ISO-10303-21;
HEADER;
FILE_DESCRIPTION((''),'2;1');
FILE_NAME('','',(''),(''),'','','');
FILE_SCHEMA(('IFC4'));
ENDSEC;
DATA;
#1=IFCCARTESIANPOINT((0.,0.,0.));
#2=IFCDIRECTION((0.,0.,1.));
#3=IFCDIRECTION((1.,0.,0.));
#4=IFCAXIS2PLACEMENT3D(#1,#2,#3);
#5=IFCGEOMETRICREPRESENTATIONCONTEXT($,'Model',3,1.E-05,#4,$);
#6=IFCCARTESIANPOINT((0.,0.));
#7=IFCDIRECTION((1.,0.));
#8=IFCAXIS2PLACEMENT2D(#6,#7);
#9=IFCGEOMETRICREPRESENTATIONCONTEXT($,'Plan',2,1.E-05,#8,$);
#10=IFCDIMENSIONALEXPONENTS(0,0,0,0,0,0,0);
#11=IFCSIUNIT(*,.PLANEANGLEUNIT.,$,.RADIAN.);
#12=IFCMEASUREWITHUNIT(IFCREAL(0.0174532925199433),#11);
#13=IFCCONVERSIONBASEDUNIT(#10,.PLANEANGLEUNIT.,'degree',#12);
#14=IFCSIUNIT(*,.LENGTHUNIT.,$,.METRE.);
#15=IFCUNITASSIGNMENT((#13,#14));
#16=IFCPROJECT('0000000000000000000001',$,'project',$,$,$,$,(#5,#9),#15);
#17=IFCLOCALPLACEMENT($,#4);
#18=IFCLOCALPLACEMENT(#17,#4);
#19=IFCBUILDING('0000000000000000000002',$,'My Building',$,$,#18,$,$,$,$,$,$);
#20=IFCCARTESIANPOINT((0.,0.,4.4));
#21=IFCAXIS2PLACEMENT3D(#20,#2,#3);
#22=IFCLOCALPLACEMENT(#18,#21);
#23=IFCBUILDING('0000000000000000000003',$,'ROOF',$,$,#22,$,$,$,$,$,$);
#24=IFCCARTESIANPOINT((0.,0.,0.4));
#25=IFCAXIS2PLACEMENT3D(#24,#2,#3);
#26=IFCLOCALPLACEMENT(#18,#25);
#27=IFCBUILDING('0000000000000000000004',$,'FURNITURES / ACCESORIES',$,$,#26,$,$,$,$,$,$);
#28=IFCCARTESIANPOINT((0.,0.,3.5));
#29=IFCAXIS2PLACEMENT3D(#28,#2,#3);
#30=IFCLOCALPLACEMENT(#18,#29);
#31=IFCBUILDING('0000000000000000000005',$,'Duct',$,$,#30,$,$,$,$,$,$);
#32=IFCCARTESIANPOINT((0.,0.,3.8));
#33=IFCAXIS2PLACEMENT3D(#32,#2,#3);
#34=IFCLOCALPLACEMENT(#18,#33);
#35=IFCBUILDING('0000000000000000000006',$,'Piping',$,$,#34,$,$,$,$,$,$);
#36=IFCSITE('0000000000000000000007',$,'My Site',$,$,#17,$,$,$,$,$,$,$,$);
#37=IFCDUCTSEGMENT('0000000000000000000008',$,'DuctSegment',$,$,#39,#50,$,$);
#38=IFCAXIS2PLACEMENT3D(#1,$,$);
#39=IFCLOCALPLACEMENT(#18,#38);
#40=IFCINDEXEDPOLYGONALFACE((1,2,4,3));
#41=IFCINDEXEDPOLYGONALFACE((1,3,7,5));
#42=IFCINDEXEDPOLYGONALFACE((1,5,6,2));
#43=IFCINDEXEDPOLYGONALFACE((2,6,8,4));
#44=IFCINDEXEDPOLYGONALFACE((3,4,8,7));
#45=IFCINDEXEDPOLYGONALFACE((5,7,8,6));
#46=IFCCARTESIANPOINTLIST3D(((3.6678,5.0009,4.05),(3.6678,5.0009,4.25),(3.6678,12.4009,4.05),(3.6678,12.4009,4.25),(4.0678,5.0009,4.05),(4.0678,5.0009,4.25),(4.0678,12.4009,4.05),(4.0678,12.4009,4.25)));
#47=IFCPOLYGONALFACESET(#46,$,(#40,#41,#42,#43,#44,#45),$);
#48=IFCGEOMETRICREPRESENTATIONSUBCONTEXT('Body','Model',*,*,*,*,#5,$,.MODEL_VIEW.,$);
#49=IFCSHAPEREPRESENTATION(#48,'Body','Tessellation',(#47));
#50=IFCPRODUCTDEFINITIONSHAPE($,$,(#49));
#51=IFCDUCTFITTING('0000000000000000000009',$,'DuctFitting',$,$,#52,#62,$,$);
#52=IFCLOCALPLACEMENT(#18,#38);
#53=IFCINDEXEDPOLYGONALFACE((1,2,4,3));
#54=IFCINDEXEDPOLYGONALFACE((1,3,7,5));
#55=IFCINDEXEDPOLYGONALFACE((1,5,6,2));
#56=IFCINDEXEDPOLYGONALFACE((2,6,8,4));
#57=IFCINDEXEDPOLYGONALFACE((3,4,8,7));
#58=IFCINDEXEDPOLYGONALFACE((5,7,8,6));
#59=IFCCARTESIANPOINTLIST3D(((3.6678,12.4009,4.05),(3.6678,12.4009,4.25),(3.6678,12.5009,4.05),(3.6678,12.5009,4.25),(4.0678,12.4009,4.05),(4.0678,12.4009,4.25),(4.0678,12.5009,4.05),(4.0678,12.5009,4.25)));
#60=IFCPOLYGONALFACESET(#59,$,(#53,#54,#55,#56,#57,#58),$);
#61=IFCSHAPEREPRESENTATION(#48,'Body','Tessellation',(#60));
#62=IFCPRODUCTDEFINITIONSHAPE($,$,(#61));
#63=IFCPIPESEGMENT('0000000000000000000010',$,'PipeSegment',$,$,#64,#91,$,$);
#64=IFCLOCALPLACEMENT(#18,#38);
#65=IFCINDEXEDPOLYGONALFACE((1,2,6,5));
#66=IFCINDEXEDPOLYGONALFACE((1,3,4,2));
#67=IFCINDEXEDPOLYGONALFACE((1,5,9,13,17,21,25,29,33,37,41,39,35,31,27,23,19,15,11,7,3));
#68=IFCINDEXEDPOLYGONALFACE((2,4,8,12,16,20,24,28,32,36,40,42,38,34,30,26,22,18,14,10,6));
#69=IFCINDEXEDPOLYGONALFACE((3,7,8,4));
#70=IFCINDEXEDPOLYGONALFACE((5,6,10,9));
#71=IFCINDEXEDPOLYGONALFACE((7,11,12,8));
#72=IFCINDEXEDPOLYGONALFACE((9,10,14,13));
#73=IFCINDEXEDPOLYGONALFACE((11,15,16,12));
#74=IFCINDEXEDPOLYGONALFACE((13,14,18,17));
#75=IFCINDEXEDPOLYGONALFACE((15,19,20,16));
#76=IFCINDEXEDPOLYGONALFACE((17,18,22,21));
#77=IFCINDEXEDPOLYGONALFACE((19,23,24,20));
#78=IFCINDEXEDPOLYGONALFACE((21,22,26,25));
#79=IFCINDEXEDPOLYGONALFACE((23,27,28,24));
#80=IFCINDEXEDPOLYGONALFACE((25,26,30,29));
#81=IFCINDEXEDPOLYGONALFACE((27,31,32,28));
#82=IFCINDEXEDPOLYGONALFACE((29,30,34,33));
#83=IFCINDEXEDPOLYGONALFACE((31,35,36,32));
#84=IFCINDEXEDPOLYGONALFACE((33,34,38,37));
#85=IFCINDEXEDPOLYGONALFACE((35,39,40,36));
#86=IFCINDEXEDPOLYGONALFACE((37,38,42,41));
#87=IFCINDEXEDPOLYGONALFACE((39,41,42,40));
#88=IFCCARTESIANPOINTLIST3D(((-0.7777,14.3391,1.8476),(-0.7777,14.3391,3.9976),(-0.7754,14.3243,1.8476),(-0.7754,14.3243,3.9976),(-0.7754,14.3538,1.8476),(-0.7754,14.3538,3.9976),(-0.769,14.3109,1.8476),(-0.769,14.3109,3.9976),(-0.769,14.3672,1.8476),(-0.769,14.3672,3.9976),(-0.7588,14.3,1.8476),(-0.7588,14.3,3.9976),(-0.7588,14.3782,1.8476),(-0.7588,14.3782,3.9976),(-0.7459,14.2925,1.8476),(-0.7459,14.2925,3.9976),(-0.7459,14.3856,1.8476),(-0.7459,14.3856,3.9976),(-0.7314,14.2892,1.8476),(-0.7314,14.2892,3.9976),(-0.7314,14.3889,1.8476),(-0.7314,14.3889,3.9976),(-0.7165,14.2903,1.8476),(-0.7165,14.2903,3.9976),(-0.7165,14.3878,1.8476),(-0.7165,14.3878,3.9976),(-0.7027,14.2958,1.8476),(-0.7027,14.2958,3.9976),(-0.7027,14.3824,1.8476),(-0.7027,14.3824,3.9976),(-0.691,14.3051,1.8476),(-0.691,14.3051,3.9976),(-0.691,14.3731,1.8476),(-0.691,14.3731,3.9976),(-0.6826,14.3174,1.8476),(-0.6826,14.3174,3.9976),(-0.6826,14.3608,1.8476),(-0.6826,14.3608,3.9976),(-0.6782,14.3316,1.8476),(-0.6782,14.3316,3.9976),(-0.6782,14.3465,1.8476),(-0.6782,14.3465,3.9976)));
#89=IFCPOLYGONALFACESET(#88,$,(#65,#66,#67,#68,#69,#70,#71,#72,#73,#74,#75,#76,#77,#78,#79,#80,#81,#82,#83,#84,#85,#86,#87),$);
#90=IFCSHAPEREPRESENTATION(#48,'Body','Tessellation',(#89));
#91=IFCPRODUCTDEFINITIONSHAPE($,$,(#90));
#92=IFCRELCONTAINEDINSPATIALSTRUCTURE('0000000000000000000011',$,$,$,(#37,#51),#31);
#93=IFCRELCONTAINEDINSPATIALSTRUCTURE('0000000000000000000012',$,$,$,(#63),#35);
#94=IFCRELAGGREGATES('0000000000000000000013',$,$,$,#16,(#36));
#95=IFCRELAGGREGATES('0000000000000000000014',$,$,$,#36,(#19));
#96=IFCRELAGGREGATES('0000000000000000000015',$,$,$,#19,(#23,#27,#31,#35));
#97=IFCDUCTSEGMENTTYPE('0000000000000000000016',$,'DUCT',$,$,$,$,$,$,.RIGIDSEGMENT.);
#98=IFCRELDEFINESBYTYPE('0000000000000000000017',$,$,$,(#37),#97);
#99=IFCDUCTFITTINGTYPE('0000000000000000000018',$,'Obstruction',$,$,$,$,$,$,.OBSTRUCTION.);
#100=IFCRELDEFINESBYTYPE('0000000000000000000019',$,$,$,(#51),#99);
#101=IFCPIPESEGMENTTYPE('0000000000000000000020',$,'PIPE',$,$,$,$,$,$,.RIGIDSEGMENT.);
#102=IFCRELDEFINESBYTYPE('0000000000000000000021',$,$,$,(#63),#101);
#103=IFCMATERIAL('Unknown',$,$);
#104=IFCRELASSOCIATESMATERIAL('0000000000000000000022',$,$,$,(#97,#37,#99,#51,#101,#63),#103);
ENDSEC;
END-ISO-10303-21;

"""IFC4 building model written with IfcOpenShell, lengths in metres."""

from ifc_helpers import new_model, entity, si_unit, converted_unit, frame, origin_with_axes, origin_2d_with_axis, place, context, subcontext, project, spatial, rectangle, circle, extrude, material, material_profile, profile_set, profile_usage, type_object, element, save


model = new_model("IFC4")

# Units and contexts
model_context = context("Model", 3, precision=1e-05, world=origin_with_axes())
plan_context = context("Plan", 2, precision=1e-05, world=origin_2d_with_axis())
body_context_1 = subcontext(model_context, "Body", "Model", "MODEL_VIEW")
ifc_project = project(units=[converted_unit("PLANEANGLEUNIT", "degree", entity("IfcReal", 0.0174532925199433), si_unit("PLANEANGLEUNIT", "RADIAN"), dimensions=[0, 0, 0, 0, 0, 0, 0]), si_unit("LENGTHUNIT", "METRE")], contexts=[model_context, plan_context])

# Site, building
site_placement = place(None, origin_with_axes())
site = spatial("IfcSite", under=ifc_project, at=site_placement, Name="My Site")
building_1_placement = place(site_placement, origin_with_axes())
building_1 = spatial("IfcBuilding", under=site, at=building_1_placement, Name="My Building")

# Shared definitions
ifc_material = material(Name="Unknown")

# Shared definitions
building_2_placement = place(building_1_placement, frame((0.0, 0.0, 4.4), z_axis=(0.0, 0.0, 1.0), x_axis=(1.0, 0.0, 0.0)))
building_2 = spatial("IfcBuilding", under=building_1, at=building_2_placement, Name="ROOF")

# Shared definitions
building_3_placement = place(building_1_placement, frame((0.0, 0.0, 0.4), z_axis=(0.0, 0.0, 1.0), x_axis=(1.0, 0.0, 0.0)))
building_3 = spatial("IfcBuilding", under=building_1, at=building_3_placement, Name="FURNITURES / ACCESORIES")

# Shared definitions
building_4_placement = place(building_1_placement, frame((0.0, 0.0, 3.5), z_axis=(0.0, 0.0, 1.0), x_axis=(1.0, 0.0, 0.0)))
building_4 = spatial("IfcBuilding", under=building_1, at=building_4_placement, Name="Duct")

# Duct segment
ifc_material_profile_1 = material_profile(ifc_material, rectangle(XDim=0.4, YDim=0.2))
ifc_profile_set_1 = profile_set([ifc_material_profile_1])
ifc_profile_usage_1 = profile_usage(ifc_profile_set_1, cardinal=5)
duct_segment_type = type_object("IfcDuctSegmentType", Name="DUCT", PredefinedType="RIGIDSEGMENT", material=ifc_profile_set_1)
duct_segment_placement = place(building_4_placement, frame((3.8678, 12.4009, 0.65), z_axis=(0.0, -1.0, 0.0), x_axis=(1.0, 0.0, 0.0)))
element("IfcDuctSegment", 1, at=duct_segment_placement, inside=building_4, type_object=duct_segment_type, material=ifc_profile_usage_1, Name="DuctSegment", context=body_context_1, shape_type="SweptSolid", body=[
    extrude(rectangle(XDim=0.4, YDim=0.2), origin_with_axes(), (0.0, 0.0, 1.0), 7.4),
])

# Duct fitting
ifc_material_profile_2 = material_profile(ifc_material, rectangle(XDim=0.4, YDim=0.2))
ifc_profile_set_2 = profile_set([ifc_material_profile_2])
ifc_profile_usage_2 = profile_usage(ifc_profile_set_2, cardinal=5)
duct_fitting_type = type_object("IfcDuctFittingType", Name="Obstruction", PredefinedType="OBSTRUCTION", material=ifc_profile_set_2)
duct_fitting_placement = place(building_4_placement, frame((3.8678, 12.5009, 0.65), z_axis=(0.0, -1.0, 0.0), x_axis=(1.0, 0.0, 0.0)))
element("IfcDuctFitting", 2, at=duct_fitting_placement, inside=building_4, type_object=duct_fitting_type, material=ifc_profile_usage_2, Name="DuctFitting", context=body_context_1, shape_type="SweptSolid", body=[
    extrude(rectangle(XDim=0.4, YDim=0.2), origin_with_axes(), (0.0, 0.0, 1.0), 0.1),
])

# Shared definitions
building_5_placement = place(building_1_placement, frame((0.0, 0.0, 3.8), z_axis=(0.0, 0.0, 1.0), x_axis=(1.0, 0.0, 0.0)))
building_5 = spatial("IfcBuilding", under=building_1, at=building_5_placement, Name="Piping")

# Pipe segment
ifc_material_profile_3 = material_profile(ifc_material, circle(Radius=0.05))
ifc_profile_set_3 = profile_set([ifc_material_profile_3])
ifc_profile_usage_3 = profile_usage(ifc_profile_set_3, cardinal=5)
pipe_segment_type = type_object("IfcPipeSegmentType", Name="PIPE", PredefinedType="RIGIDSEGMENT", material=ifc_profile_set_3)
pipe_segment_1_placement = place(building_5_placement, frame((-0.7277, 14.3391, -1.9524), z_axis=(0.0, 0.0, 1.0), x_axis=(-1.0, 0.0, 0.0)))
element("IfcPipeSegment", 3, at=pipe_segment_1_placement, inside=building_5, type_object=pipe_segment_type, material=ifc_profile_usage_3, Name="PipeSegment", context=body_context_1, shape_type="SweptSolid", body=[
    extrude(circle(Radius=0.05), origin_with_axes(), (0.0, 0.0, 1.0), 2.15),
])

save(model, "model.ifc")
